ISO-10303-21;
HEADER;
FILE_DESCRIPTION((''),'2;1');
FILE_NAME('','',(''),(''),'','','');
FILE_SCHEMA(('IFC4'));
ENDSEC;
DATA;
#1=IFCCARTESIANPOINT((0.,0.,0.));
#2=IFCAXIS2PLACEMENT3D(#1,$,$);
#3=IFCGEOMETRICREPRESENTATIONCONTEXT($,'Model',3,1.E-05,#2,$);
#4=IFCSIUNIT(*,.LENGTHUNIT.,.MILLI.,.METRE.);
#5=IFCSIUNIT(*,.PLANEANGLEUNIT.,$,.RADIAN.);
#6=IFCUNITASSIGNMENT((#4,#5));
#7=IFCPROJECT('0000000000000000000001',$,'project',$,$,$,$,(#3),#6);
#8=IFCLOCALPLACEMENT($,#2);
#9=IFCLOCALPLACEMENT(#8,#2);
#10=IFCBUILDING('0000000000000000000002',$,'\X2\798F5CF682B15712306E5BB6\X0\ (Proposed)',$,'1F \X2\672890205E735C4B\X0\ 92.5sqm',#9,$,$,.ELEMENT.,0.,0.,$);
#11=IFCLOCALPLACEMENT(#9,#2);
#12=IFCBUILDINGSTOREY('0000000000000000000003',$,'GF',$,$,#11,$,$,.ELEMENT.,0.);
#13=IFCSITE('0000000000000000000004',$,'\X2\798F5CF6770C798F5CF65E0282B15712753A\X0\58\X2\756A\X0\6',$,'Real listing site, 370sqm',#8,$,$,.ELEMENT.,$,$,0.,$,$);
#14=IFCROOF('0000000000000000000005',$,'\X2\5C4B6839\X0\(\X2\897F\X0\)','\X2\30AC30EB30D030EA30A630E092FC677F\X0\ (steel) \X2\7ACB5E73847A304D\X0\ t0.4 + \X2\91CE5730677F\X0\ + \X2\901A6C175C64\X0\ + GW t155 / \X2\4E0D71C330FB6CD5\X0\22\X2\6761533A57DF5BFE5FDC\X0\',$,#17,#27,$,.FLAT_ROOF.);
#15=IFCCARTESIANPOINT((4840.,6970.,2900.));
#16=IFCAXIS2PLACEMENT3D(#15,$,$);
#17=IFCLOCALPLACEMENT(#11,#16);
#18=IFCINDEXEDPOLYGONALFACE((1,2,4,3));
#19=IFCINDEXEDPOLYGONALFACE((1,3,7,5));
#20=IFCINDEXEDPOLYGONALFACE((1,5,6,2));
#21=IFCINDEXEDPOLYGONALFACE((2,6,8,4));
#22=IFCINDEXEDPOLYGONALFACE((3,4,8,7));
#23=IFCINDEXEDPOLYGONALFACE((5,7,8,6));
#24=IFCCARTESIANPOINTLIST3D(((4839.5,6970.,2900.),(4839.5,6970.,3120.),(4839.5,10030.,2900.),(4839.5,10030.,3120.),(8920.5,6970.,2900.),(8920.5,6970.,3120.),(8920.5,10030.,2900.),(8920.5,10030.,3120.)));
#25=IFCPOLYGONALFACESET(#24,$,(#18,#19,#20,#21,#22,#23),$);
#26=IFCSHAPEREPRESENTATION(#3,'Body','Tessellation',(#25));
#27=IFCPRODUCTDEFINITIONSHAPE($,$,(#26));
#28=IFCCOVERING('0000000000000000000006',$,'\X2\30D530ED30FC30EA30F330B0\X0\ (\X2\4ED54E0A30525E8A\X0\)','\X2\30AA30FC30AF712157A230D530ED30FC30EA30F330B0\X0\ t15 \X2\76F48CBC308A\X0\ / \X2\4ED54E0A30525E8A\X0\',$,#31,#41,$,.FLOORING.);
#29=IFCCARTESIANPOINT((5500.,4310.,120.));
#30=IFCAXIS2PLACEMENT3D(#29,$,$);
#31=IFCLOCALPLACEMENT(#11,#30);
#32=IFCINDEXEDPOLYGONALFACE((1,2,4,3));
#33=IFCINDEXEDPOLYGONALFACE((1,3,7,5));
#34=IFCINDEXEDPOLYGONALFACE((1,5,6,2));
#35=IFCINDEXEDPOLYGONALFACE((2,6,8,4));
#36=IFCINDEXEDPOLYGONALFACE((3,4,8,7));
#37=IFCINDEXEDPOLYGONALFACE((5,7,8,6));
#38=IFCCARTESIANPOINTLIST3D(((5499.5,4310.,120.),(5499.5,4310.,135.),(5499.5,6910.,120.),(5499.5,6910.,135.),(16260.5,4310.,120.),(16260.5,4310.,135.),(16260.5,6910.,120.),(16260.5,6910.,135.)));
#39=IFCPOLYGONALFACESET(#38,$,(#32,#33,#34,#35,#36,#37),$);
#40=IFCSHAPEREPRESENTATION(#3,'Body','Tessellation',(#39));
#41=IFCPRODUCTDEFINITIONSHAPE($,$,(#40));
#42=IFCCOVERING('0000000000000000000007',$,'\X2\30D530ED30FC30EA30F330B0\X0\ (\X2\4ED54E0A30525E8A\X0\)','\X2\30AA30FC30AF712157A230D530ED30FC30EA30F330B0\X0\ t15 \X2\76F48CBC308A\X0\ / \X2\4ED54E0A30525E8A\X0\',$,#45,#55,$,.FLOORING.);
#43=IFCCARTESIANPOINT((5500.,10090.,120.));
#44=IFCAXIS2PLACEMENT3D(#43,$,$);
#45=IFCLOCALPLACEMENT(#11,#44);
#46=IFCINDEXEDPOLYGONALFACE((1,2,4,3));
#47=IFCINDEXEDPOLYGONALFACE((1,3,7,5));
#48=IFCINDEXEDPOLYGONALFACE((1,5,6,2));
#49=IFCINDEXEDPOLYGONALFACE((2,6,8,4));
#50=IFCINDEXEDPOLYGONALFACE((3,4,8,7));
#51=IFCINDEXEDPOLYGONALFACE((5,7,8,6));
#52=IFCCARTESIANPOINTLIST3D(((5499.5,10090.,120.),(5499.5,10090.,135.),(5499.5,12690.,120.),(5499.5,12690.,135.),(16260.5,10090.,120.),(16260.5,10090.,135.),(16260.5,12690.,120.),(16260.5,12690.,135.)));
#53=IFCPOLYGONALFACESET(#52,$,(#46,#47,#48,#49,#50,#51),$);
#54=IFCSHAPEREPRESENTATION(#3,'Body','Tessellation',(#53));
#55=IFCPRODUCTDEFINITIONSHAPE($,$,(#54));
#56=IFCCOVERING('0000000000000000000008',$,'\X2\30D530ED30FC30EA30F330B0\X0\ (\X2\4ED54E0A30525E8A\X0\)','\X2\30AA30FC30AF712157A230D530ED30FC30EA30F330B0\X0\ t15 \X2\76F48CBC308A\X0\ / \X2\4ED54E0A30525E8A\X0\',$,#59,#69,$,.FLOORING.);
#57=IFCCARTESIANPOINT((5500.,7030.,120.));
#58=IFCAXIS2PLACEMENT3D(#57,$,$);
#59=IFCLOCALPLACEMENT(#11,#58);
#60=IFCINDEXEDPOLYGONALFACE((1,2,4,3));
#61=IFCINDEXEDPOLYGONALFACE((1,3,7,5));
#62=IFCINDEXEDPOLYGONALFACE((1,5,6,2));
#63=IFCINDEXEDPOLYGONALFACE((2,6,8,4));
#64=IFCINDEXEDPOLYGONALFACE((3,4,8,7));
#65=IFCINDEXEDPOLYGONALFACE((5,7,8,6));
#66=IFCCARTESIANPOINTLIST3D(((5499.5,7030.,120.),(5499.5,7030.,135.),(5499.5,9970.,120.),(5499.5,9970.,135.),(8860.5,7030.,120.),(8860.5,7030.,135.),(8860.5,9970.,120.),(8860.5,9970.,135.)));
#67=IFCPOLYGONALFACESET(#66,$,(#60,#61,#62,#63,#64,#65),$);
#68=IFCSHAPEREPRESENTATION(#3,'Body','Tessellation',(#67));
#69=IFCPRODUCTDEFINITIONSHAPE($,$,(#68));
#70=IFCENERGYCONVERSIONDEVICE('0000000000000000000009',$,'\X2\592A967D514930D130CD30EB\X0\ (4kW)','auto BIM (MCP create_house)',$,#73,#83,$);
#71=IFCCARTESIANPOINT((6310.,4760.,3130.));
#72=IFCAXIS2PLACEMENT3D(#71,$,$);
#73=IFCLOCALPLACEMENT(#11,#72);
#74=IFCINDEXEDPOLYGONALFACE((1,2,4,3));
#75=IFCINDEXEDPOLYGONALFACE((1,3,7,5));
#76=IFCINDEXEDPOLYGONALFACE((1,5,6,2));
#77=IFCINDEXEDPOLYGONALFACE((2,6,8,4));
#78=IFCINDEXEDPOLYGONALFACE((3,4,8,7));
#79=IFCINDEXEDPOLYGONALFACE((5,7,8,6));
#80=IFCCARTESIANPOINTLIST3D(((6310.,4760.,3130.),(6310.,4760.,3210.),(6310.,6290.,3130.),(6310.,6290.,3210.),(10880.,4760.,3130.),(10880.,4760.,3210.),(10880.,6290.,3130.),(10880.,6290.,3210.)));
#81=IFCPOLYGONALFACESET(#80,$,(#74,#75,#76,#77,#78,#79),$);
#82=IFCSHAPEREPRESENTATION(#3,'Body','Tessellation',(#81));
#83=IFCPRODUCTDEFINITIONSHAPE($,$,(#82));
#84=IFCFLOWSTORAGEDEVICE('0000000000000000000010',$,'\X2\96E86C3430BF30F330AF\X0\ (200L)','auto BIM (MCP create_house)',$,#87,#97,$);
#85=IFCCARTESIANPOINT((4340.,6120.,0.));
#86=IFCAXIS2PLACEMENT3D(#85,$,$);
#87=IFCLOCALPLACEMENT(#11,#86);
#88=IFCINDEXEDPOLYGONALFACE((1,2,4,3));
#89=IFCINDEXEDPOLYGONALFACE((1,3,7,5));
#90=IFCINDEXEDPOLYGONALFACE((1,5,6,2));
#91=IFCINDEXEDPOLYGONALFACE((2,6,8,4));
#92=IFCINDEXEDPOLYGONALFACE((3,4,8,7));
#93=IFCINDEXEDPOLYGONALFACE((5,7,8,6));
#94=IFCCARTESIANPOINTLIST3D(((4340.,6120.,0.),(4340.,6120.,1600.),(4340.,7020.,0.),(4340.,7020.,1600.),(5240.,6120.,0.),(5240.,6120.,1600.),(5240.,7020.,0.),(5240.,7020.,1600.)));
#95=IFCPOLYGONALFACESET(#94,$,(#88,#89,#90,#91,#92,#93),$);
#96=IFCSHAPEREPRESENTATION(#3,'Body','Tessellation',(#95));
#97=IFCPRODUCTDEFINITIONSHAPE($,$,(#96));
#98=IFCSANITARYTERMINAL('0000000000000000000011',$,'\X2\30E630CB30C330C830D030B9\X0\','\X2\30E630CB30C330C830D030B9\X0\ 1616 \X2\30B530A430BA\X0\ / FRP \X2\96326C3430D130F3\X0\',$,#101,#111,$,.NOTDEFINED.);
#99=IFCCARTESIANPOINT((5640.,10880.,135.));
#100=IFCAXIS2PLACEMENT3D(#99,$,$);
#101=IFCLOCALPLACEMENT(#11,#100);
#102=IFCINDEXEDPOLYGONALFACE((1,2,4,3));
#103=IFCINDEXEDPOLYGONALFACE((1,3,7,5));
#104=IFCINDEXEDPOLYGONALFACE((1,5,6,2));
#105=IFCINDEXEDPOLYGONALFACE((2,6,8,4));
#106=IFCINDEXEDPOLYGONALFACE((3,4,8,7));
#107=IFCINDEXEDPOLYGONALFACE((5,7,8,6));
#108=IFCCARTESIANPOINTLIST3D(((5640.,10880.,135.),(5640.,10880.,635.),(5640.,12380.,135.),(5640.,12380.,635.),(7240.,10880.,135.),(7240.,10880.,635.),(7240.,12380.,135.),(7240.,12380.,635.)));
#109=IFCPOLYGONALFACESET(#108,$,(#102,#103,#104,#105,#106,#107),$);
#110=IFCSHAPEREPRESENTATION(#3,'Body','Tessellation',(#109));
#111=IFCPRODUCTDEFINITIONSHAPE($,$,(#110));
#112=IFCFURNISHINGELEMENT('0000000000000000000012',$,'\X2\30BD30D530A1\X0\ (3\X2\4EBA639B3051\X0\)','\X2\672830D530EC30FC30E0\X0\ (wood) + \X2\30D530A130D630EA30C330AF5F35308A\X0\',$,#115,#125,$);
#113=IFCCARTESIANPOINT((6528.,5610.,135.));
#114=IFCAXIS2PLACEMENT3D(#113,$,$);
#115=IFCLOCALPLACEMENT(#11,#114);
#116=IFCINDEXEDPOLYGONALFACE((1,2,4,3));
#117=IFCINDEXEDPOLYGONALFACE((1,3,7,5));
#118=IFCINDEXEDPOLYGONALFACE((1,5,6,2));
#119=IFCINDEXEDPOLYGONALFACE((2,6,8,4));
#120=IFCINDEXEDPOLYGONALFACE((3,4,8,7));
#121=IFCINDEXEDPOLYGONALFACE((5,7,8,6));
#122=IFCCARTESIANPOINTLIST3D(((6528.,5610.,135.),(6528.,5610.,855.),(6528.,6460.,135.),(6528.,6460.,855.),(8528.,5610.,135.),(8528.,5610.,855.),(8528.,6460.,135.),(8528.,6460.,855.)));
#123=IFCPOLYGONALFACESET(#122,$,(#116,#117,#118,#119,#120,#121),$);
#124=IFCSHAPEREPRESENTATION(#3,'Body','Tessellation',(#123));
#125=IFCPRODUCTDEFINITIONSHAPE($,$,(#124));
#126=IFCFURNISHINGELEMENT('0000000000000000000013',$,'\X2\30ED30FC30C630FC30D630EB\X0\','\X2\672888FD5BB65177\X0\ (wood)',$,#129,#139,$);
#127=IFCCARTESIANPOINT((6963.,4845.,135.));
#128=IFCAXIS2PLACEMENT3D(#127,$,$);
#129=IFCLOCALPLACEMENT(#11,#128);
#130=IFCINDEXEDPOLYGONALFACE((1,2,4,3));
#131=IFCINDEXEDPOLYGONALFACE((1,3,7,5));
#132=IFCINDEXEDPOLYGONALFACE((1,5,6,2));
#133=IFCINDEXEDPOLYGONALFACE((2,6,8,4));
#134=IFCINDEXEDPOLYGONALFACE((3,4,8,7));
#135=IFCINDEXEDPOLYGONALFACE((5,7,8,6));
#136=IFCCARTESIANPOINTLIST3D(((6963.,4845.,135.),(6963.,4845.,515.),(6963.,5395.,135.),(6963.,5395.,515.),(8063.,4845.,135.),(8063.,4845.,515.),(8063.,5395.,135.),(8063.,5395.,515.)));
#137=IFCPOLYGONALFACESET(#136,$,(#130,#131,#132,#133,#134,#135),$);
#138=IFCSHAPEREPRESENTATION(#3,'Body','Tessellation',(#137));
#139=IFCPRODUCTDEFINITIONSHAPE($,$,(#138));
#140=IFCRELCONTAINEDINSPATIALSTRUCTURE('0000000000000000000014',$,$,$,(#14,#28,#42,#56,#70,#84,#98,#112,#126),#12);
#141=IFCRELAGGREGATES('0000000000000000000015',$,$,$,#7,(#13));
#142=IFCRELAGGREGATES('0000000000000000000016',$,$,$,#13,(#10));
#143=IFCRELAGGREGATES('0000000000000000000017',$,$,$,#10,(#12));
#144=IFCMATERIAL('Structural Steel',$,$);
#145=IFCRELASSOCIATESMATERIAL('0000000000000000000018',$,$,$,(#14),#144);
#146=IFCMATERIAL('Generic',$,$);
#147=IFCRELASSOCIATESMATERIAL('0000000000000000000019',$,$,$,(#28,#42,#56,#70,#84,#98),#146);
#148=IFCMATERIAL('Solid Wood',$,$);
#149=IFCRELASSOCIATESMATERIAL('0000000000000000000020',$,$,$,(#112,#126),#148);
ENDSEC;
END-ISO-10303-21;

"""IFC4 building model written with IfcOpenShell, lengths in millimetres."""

from ifc_helpers import new_model, si_unit, frame, frame_2d, origin, place, context, project, spatial, rectangle, extrude, material, element, save


model = new_model("IFC4")

# Units and contexts
model_context = context("Model", 3, precision=1e-05, world=origin())
ifc_project = project(units=[si_unit("LENGTHUNIT", "METRE", prefix="MILLI"), si_unit("PLANEANGLEUNIT", "RADIAN")], contexts=[model_context])

# Site, building, storey
site_placement = place(None, origin())
site = spatial("IfcSite", under=ifc_project, at=site_placement, Name="福島県福島市花園町58番6", ObjectType="Real listing site, 370sqm", CompositionType="ELEMENT", RefElevation=0.0)
building_placement = place(site_placement, origin())
building = spatial("IfcBuilding", under=site, at=building_placement, Name="福島花園の家 (Proposed)", ObjectType="1F 木造平屋 92.5sqm", CompositionType="ELEMENT", ElevationOfRefHeight=0.0, ElevationOfTerrain=0.0)
storey_placement = place(building_placement, origin())
storey = spatial("IfcBuildingStorey", under=building, at=storey_placement, Name="GF", CompositionType="ELEMENT", Elevation=0.0)

# Shared definitions
ifc_material_1 = material(Name="Solid Wood")

# Roof
ifc_material_2 = material(Name="Structural Steel")
roof_1_placement = place(storey_placement, frame((4840.0, 6970.0, 2900.0)))
element("IfcRoof", 1, at=roof_1_placement, inside=storey, material=ifc_material_2, Name="屋根(西)", Description="ガルバリウム鋼板 (steel) 立平葺き t0.4 + 野地板 + 通気層 + GW t155 / 不燃・法22条区域対応", PredefinedType="FLAT_ROOF", context=model_context, shape_type="SweptSolid", body=[
    extrude(rectangle(XDim=4081.0, YDim=3060.0, at=frame_2d((2040.0, 1530.0))), frame((4840.0, 6970.0, 2900.0)), (0.0, 0.0, 1.0), 220.0),
])

# Coverings
ifc_material_3 = material(Name="Generic")
covering_1_placement = place(storey_placement, frame((5500.0, 4310.0, 120.0)))
element("IfcCovering", 2, at=covering_1_placement, inside=storey, material=ifc_material_3, Name="フローリング (仕上げ床)", Description="オーク無垢フローリング t15 直貼り / 仕上げ床", PredefinedType="FLOORING", context=model_context, shape_type="SweptSolid", body=[
    extrude(rectangle(XDim=10761.0, YDim=2600.0, at=frame_2d((5380.0, 1300.0))), frame((5500.0, 4310.0, 120.0)), (0.0, 0.0, 1.0), 15.0),
])
covering_2_placement = place(storey_placement, frame((5500.0, 10090.0, 120.0)))
element("IfcCovering", 3, at=covering_2_placement, inside=storey, material=ifc_material_3, Name="フローリング (仕上げ床)", Description="オーク無垢フローリング t15 直貼り / 仕上げ床", PredefinedType="FLOORING", context=model_context, shape_type="SweptSolid", body=[
    extrude(rectangle(XDim=10761.0, YDim=2600.0, at=frame_2d((5380.0, 1300.0))), frame((5500.0, 10090.0, 120.0)), (0.0, 0.0, 1.0), 15.0),
])
covering_3_placement = place(storey_placement, frame((5500.0, 7030.0, 120.0)))
element("IfcCovering", 4, at=covering_3_placement, inside=storey, material=ifc_material_3, Name="フローリング (仕上げ床)", Description="オーク無垢フローリング t15 直貼り / 仕上げ床", PredefinedType="FLOORING", context=model_context, shape_type="SweptSolid", body=[
    extrude(rectangle(XDim=3361.0, YDim=2940.0, at=frame_2d((1680.0, 1470.0))), frame((5500.0, 7030.0, 120.0)), (0.0, 0.0, 1.0), 15.0),
])

# Energy conversion device
energy_conversion_device_placement = place(storey_placement, frame((6310.0, 4760.0, 3130.0)))
element("IfcEnergyConversionDevice", 5, at=energy_conversion_device_placement, inside=storey, material=ifc_material_3, Name="太陽光パネル (4kW)", Description="auto BIM (MCP create_house)", context=model_context, shape_type="SweptSolid", body=[
    extrude(rectangle(XDim=4570.0, YDim=1530.0, at=frame_2d((2285.0, 765.0))), frame((6310.0, 4760.0, 3130.0)), (0.0, 0.0, 1.0), 80.0),
])

# Flow storage device
flow_storage_device_placement = place(storey_placement, frame((4340.0, 6120.0, 0.0)))
element("IfcFlowStorageDevice", 6, at=flow_storage_device_placement, inside=storey, material=ifc_material_3, Name="雨水タンク (200L)", Description="auto BIM (MCP create_house)", context=model_context, shape_type="SweptSolid", body=[
    extrude(rectangle(XDim=900.0, YDim=900.0, at=frame_2d((450.0, 450.0))), frame((4340.0, 6120.0, 0.0)), (0.0, 0.0, 1.0), 1600.0),
])

# Sanitary terminal
sanitary_terminal_placement = place(storey_placement, frame((5640.0, 10880.0, 135.0)))
element("IfcSanitaryTerminal", 7, at=sanitary_terminal_placement, inside=storey, material=ifc_material_3, Name="ユニットバス", Description="ユニットバス 1616 サイズ / FRP 防水パン", PredefinedType="NOTDEFINED", context=model_context, shape_type="SweptSolid", body=[
    extrude(rectangle(XDim=1600.0, YDim=1500.0, at=frame_2d((800.0, 750.0))), frame((5640.0, 10880.0, 135.0)), (0.0, 0.0, 1.0), 500.0),
])

# Furnishing elements
furnishing_1_placement = place(storey_placement, frame((6528.0, 5610.0, 135.0)))
element("IfcFurnishingElement", 8, at=furnishing_1_placement, inside=storey, material=ifc_material_1, Name="ソファ (3人掛け)", Description="木フレーム (wood) + ファブリック張り", context=model_context, shape_type="SweptSolid", body=[
    extrude(rectangle(XDim=2000.0, YDim=850.0, at=frame_2d((1000.0, 425.0))), frame((6528.0, 5610.0, 135.0)), (0.0, 0.0, 1.0), 720.0),
])
furnishing_2_placement = place(storey_placement, frame((6963.0, 4845.0, 135.0)))
element("IfcFurnishingElement", 9, at=furnishing_2_placement, inside=storey, material=ifc_material_1, Name="ローテーブル", Description="木製家具 (wood)", context=model_context, shape_type="SweptSolid", body=[
    extrude(rectangle(XDim=1100.0, YDim=550.0, at=frame_2d((550.0, 275.0))), frame((6963.0, 4845.0, 135.0)), (0.0, 0.0, 1.0), 380.0),
])

save(model, "model.ifc")
